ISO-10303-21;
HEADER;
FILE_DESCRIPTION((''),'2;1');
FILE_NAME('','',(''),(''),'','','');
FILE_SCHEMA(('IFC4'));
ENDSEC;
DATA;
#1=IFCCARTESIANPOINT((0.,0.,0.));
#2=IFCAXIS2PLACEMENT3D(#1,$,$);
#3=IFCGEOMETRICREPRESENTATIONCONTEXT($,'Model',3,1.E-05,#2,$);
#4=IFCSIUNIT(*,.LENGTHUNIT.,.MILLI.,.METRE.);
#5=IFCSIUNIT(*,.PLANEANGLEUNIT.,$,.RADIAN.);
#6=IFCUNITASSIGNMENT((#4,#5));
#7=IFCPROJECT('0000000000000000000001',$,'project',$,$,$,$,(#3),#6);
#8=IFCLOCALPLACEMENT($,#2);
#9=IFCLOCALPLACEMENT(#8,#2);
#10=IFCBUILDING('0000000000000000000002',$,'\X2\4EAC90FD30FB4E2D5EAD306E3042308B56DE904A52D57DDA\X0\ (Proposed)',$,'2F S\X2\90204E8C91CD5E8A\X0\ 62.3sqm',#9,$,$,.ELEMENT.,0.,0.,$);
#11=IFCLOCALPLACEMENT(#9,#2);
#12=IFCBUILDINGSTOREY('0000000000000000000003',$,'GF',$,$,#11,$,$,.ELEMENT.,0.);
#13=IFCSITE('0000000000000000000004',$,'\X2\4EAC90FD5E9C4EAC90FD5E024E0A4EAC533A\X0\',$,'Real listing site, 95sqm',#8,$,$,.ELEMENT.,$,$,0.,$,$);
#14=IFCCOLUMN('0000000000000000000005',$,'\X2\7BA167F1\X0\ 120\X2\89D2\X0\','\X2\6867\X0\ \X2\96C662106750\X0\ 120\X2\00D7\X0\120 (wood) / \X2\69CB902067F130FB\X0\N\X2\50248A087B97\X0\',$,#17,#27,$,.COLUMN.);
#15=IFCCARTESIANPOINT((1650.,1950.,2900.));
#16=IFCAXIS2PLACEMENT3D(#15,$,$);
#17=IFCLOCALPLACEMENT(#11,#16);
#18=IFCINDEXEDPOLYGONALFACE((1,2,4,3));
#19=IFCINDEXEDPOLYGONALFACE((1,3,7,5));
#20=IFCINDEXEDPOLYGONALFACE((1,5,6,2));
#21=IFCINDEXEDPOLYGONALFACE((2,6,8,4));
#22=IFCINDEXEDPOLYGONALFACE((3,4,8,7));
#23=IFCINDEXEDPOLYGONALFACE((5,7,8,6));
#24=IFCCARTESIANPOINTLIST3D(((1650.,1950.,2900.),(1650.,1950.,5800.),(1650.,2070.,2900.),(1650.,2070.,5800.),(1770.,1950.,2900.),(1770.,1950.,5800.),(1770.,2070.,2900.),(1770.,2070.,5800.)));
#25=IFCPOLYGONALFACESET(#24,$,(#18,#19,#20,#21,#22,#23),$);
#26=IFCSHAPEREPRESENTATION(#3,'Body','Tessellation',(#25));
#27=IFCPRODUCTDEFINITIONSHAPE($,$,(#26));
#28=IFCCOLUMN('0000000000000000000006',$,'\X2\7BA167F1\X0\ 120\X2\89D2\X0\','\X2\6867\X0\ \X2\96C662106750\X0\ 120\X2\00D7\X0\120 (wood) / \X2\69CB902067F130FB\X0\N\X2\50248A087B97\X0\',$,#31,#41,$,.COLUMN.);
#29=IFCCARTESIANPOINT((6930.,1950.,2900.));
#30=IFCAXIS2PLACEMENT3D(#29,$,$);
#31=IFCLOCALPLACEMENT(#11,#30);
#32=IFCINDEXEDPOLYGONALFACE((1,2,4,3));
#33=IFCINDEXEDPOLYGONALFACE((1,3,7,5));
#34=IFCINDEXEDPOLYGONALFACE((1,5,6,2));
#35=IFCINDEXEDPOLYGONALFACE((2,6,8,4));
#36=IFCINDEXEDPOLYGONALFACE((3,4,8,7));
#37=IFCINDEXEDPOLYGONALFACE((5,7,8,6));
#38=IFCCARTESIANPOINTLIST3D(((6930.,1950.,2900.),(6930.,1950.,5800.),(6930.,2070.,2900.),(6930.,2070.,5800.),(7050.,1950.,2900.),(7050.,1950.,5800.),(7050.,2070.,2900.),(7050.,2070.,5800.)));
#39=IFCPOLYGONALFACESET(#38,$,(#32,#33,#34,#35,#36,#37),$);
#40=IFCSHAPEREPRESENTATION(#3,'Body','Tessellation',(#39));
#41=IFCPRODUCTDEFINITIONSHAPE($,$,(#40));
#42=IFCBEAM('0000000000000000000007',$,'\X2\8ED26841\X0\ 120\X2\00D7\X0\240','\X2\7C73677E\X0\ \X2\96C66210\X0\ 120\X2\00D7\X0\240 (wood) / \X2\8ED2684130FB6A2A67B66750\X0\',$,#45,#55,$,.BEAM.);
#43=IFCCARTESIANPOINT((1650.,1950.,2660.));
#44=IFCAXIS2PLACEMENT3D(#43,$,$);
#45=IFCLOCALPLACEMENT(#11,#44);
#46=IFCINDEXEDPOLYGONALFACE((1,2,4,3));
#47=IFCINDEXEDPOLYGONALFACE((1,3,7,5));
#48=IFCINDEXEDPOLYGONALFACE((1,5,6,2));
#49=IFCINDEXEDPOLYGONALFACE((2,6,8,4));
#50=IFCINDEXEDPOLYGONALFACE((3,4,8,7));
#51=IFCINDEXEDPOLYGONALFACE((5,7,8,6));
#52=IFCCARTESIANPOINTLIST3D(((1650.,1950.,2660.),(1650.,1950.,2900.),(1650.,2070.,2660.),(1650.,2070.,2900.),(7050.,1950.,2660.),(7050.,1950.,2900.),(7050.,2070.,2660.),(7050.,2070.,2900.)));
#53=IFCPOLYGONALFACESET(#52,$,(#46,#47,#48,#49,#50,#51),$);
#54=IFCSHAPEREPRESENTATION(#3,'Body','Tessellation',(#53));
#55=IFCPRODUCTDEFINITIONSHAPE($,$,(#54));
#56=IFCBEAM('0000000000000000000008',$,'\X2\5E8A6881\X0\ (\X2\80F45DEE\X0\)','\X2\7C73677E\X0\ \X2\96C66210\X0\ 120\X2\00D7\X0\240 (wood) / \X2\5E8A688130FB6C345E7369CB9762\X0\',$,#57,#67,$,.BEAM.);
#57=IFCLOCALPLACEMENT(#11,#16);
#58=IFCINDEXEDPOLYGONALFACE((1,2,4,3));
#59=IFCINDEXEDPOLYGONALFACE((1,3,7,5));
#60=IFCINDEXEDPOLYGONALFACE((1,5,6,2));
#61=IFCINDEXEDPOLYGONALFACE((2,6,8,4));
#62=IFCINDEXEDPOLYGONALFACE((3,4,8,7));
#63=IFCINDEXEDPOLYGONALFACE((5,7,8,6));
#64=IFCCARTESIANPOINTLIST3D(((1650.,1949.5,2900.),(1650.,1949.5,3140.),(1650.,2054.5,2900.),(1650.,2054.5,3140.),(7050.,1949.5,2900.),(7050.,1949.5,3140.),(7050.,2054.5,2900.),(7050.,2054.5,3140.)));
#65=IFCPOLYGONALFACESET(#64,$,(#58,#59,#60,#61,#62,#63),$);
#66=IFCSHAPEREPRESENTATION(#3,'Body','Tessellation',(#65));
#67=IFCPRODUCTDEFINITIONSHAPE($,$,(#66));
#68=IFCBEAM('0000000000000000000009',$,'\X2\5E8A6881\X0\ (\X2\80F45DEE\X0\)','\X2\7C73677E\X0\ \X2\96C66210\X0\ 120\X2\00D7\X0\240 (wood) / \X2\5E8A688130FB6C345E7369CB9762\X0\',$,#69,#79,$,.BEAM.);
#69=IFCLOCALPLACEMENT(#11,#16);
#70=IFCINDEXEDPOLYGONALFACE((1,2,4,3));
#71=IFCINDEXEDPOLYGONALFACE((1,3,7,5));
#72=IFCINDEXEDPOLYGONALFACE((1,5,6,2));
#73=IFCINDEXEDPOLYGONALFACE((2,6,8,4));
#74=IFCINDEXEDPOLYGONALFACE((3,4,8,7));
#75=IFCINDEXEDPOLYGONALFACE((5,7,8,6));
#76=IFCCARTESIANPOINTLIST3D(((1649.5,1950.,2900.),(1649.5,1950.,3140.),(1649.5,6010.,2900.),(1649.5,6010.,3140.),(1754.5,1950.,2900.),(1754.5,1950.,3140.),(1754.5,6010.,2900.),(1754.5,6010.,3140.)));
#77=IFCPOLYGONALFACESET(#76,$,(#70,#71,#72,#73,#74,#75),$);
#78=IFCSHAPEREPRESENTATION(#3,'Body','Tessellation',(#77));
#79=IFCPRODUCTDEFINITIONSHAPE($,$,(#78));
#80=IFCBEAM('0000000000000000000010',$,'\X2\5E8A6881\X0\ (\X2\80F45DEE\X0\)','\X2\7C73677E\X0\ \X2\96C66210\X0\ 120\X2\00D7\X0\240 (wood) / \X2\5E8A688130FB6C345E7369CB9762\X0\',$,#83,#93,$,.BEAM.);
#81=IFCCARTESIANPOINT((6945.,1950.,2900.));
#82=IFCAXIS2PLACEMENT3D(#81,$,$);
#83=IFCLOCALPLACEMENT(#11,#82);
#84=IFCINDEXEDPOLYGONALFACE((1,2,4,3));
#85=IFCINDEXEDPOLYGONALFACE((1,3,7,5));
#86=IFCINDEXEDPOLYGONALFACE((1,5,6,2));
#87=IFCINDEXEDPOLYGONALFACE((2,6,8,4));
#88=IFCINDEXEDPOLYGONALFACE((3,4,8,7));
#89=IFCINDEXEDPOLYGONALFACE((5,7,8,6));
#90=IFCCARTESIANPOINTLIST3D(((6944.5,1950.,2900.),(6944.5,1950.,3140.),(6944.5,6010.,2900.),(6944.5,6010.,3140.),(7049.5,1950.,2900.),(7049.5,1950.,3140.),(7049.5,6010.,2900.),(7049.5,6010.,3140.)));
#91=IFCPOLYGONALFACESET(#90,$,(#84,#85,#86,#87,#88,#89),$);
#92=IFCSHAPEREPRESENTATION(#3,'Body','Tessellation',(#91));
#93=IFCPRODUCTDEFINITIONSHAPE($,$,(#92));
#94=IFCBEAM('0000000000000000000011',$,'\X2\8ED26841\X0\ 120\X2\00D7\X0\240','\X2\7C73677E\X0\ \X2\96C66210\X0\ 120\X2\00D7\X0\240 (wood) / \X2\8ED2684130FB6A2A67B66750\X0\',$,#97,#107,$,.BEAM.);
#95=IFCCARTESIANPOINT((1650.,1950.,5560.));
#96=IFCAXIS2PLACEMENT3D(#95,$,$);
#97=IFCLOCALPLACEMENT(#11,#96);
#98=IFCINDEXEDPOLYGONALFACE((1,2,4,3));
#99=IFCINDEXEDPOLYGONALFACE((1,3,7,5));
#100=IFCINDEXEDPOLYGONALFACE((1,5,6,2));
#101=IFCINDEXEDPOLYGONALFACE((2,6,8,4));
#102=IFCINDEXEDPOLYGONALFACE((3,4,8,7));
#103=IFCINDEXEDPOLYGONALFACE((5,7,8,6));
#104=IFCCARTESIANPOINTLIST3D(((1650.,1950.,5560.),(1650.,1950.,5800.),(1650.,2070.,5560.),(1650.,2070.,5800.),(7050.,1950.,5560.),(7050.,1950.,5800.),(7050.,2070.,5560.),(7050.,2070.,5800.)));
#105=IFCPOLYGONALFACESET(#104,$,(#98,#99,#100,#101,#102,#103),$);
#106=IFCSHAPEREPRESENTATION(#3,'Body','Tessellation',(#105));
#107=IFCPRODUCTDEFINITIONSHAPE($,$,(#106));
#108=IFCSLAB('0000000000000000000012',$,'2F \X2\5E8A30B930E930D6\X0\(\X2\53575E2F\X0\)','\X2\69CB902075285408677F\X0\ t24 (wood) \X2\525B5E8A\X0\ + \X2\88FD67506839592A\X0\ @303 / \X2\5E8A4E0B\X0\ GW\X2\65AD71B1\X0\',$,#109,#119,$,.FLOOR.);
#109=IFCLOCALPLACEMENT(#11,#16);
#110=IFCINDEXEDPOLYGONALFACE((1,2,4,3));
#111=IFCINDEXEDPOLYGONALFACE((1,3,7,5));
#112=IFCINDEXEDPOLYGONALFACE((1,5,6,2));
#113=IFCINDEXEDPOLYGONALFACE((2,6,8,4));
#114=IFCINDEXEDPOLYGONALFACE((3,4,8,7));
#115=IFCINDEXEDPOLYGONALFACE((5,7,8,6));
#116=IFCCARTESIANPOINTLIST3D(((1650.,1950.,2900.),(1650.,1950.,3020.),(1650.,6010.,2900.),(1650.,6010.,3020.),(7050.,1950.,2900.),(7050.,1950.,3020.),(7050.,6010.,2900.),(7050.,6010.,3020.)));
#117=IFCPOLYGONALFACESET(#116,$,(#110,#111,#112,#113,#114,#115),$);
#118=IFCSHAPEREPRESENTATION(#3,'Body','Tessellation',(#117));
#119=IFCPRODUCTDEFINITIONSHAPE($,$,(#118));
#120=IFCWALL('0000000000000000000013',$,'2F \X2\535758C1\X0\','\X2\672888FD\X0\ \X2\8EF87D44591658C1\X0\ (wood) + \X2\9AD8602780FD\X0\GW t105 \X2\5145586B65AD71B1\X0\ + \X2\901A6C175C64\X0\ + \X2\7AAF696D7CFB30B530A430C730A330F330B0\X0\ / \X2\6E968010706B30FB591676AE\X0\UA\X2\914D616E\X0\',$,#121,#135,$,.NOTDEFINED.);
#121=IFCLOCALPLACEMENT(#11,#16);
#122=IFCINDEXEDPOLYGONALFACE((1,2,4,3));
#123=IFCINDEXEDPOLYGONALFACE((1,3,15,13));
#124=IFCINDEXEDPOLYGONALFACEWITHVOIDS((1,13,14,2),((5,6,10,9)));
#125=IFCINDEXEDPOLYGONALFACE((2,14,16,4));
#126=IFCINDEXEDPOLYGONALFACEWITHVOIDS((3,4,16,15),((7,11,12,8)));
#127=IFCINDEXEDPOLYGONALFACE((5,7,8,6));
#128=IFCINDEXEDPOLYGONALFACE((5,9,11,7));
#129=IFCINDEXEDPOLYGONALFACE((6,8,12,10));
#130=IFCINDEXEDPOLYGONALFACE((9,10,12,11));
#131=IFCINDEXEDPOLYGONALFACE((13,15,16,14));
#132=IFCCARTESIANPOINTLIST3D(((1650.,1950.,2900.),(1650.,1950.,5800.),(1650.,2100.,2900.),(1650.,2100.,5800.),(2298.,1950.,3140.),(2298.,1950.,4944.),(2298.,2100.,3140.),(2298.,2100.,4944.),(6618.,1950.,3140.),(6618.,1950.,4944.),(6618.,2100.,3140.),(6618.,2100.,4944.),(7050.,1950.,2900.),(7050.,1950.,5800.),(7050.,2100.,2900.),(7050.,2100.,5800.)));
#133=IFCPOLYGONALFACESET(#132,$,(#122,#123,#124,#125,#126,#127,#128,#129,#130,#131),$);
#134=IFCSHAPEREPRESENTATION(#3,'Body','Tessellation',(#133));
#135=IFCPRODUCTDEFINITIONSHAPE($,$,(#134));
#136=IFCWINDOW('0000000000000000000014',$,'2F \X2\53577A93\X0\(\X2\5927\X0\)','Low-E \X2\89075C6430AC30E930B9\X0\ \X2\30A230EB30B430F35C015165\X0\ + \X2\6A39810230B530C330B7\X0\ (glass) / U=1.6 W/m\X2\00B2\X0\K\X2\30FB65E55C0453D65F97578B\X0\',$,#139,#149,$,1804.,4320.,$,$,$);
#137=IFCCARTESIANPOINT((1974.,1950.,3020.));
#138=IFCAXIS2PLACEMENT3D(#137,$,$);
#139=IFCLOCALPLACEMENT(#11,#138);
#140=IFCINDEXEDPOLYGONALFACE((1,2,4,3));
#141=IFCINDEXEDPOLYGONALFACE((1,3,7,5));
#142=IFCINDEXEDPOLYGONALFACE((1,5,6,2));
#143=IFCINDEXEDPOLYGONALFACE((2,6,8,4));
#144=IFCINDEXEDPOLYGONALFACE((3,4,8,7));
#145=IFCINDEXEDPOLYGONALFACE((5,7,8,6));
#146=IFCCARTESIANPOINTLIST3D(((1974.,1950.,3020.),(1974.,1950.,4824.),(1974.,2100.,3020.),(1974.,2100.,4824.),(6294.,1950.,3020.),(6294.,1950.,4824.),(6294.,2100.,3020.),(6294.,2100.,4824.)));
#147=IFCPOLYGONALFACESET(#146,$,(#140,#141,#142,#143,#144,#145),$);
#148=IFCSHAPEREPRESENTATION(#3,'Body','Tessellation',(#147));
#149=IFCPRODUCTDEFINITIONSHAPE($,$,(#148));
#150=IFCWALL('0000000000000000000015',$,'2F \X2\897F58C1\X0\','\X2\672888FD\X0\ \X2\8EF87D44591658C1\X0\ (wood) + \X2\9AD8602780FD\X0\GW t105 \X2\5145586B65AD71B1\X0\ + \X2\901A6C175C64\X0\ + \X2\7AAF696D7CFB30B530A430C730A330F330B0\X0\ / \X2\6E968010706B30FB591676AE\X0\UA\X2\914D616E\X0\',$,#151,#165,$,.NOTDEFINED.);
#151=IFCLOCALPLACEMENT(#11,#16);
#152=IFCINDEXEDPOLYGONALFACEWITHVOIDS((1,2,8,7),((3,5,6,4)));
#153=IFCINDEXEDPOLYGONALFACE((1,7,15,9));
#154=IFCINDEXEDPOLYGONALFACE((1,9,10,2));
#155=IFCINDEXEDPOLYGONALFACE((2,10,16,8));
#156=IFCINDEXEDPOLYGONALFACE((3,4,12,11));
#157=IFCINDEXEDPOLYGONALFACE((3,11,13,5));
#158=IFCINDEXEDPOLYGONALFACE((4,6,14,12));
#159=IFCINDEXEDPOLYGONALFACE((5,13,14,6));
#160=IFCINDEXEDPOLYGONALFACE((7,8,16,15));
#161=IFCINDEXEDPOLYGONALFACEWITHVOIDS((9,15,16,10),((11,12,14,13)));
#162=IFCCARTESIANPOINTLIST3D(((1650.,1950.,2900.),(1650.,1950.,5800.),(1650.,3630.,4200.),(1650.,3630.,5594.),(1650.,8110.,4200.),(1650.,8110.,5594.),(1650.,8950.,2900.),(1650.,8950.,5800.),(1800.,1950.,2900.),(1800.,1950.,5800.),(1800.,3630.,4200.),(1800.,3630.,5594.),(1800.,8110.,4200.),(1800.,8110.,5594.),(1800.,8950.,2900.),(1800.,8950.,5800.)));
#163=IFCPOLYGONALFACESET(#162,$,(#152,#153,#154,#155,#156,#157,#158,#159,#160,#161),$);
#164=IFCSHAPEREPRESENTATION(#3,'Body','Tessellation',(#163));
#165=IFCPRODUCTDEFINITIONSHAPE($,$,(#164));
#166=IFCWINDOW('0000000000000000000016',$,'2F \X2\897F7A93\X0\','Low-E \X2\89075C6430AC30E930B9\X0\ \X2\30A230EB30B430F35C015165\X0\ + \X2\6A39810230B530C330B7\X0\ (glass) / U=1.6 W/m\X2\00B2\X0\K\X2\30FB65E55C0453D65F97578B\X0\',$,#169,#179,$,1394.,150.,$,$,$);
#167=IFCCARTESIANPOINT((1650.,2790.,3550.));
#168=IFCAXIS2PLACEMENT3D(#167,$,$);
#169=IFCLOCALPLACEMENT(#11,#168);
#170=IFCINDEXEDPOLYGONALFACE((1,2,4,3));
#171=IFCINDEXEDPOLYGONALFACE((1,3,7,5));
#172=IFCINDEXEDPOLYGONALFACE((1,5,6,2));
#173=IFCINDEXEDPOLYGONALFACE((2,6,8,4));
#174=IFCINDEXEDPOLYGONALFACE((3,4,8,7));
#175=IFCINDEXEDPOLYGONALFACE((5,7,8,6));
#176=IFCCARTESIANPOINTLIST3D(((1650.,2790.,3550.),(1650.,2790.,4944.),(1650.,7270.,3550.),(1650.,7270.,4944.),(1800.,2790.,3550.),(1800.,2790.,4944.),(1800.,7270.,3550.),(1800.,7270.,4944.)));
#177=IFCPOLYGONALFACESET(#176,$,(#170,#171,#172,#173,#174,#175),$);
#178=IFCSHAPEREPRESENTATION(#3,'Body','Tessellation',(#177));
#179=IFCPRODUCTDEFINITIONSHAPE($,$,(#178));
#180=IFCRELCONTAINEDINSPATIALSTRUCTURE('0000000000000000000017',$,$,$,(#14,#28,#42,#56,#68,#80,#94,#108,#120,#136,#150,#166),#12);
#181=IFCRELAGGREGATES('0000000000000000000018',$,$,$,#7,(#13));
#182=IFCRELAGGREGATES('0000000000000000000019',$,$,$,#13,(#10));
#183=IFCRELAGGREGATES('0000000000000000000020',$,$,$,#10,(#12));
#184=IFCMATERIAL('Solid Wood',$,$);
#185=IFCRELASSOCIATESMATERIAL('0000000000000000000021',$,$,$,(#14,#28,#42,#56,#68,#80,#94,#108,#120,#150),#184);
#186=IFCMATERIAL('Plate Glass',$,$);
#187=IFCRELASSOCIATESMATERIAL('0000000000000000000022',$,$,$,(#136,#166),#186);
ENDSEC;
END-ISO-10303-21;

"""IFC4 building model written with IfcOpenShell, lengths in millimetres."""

from ifc_helpers import new_model, si_unit, frame, frame_2d, origin, place, context, project, spatial, rectangle, extrude, material, element, fill, save


model = new_model("IFC4")

# Units and contexts
model_context = context("Model", 3, precision=1e-05, world=origin())
ifc_project = project(units=[si_unit("LENGTHUNIT", "METRE", prefix="MILLI"), si_unit("PLANEANGLEUNIT", "RADIAN")], contexts=[model_context])

# Site, building, storey
site_placement = place(None, origin())
site = spatial("IfcSite", under=ifc_project, at=site_placement, Name="京都府京都市上京区", ObjectType="Real listing site, 95sqm", CompositionType="ELEMENT", RefElevation=0.0)
building_placement = place(site_placement, origin())
building = spatial("IfcBuilding", under=site, at=building_placement, Name="京都・中庭のある回遊動線 (Proposed)", ObjectType="2F S造二重床 62.3sqm", CompositionType="ELEMENT", ElevationOfRefHeight=0.0, ElevationOfTerrain=0.0)
storey_placement = place(building_placement, origin())
storey = spatial("IfcBuildingStorey", under=building, at=storey_placement, Name="GF", CompositionType="ELEMENT", Elevation=0.0)

# Columns
ifc_material_1 = material(Name="Solid Wood")
column_1_placement = place(storey_placement, frame((1650.0, 1950.0, 2900.0)))
element("IfcColumn", 1, at=column_1_placement, inside=storey, material=ifc_material_1, Name="管柱 120角", Description="桧 集成材 120×120 (wood) / 構造柱・N値計算", PredefinedType="COLUMN", context=model_context, shape_type="SweptSolid", body=[
    extrude(rectangle(XDim=120.0, YDim=120.0, at=frame_2d((60.0, 60.0))), frame((1650.0, 1950.0, 2900.0)), (0.0, 0.0, 1.0), 2900.0),
])
column_2_placement = place(storey_placement, frame((6930.0, 1950.0, 2900.0)))
element("IfcColumn", 2, at=column_2_placement, inside=storey, material=ifc_material_1, Name="管柱 120角", Description="桧 集成材 120×120 (wood) / 構造柱・N値計算", PredefinedType="COLUMN", context=model_context, shape_type="SweptSolid", body=[
    extrude(rectangle(XDim=120.0, YDim=120.0, at=frame_2d((60.0, 60.0))), frame((6930.0, 1950.0, 2900.0)), (0.0, 0.0, 1.0), 2900.0),
])

# Beams
beam_1_placement = place(storey_placement, frame((1650.0, 1950.0, 2660.0)))
element("IfcBeam", 3, at=beam_1_placement, inside=storey, material=ifc_material_1, Name="軒桁 120×240", Description="米松 集成 120×240 (wood) / 軒桁・横架材", PredefinedType="BEAM", context=model_context, shape_type="SweptSolid", body=[
    extrude(rectangle(XDim=5400.0, YDim=120.0, at=frame_2d((2700.0, 60.0))), frame((1650.0, 1950.0, 2660.0)), (0.0, 0.0, 1.0), 240.0),
])
beam_2_placement = place(storey_placement, frame((1650.0, 1950.0, 2900.0)))
element("IfcBeam", 4, at=beam_2_placement, inside=storey, material=ifc_material_1, Name="床梁 (胴差)", Description="米松 集成 120×240 (wood) / 床梁・水平構面", PredefinedType="BEAM", context=model_context, shape_type="SweptSolid", body=[
    extrude(rectangle(XDim=5400.0, YDim=105.0, at=frame_2d((2700.0, 52.0))), frame((1650.0, 1950.0, 2900.0)), (0.0, 0.0, 1.0), 240.0),
])
beam_3_placement = place(storey_placement, frame((1650.0, 1950.0, 2900.0)))
element("IfcBeam", 5, at=beam_3_placement, inside=storey, material=ifc_material_1, Name="床梁 (胴差)", Description="米松 集成 120×240 (wood) / 床梁・水平構面", PredefinedType="BEAM", context=model_context, shape_type="SweptSolid", body=[
    extrude(rectangle(XDim=105.0, YDim=4060.0, at=frame_2d((52.0, 2030.0))), frame((1650.0, 1950.0, 2900.0)), (0.0, 0.0, 1.0), 240.0),
])
beam_4_placement = place(storey_placement, frame((6945.0, 1950.0, 2900.0)))
element("IfcBeam", 6, at=beam_4_placement, inside=storey, material=ifc_material_1, Name="床梁 (胴差)", Description="米松 集成 120×240 (wood) / 床梁・水平構面", PredefinedType="BEAM", context=model_context, shape_type="SweptSolid", body=[
    extrude(rectangle(XDim=105.0, YDim=4060.0, at=frame_2d((52.0, 2030.0))), frame((6945.0, 1950.0, 2900.0)), (0.0, 0.0, 1.0), 240.0),
])
beam_5_placement = place(storey_placement, frame((1650.0, 1950.0, 5560.0)))
element("IfcBeam", 7, at=beam_5_placement, inside=storey, material=ifc_material_1, Name="軒桁 120×240", Description="米松 集成 120×240 (wood) / 軒桁・横架材", PredefinedType="BEAM", context=model_context, shape_type="SweptSolid", body=[
    extrude(rectangle(XDim=5400.0, YDim=120.0, at=frame_2d((2700.0, 60.0))), frame((1650.0, 1950.0, 5560.0)), (0.0, 0.0, 1.0), 240.0),
])

# Slab
slab_placement = place(storey_placement, frame((1650.0, 1950.0, 2900.0)))
element("IfcSlab", 8, at=slab_placement, inside=storey, material=ifc_material_1, Name="2F 床スラブ(南帯)", Description="構造用合板 t24 (wood) 剛床 + 製材根太 @303 / 床下 GW断熱", PredefinedType="FLOOR", context=model_context, shape_type="SweptSolid", body=[
    extrude(rectangle(XDim=5400.0, YDim=4060.0, at=frame_2d((2700.0, 2030.0))), frame((1650.0, 1950.0, 2900.0)), (0.0, 0.0, 1.0), 120.0),
])

# Walls, openings, windows
wall_1_placement = place(storey_placement, frame((1650.0, 1950.0, 2900.0)))
wall_1 = element("IfcWall", 9, at=wall_1_placement, inside=storey, material=ifc_material_1, Name="2F 南壁", Description="木製 軸組外壁 (wood) + 高性能GW t105 充填断熱 + 通気層 + 窯業系サイディング / 準耐火・外皮UA配慮", PredefinedType="NOTDEFINED", context=model_context, shape_type="SweptSolid", body=[
    extrude(rectangle(XDim=5400.0, YDim=150.0, at=frame_2d((2700.0, 75.0))), frame((1650.0, 1950.0, 2900.0)), (0.0, 0.0, 1.0), 2900.0),
])
opening_1_placement = place(storey_placement, frame((1974.0, 1950.0, 3020.0)))
opening_1 = element("IfcOpeningElement", 10, at=opening_1_placement, cuts=wall_1, PredefinedType="NOTDEFINED", context=model_context, shape_type="SweptSolid", body=[
    extrude(rectangle(XDim=4320.0, YDim=150.0, at=frame_2d((2160.0, 75.0))), frame((1974.0, 1950.0, 3020.0)), (0.0, 0.0, 1.0), 1804.0),
])
ifc_material_2 = material(Name="Plate Glass")
window_1_placement = place(storey_placement, frame((1974.0, 1950.0, 3020.0)))
window_1 = element("IfcWindow", 11, at=window_1_placement, inside=storey, material=ifc_material_2, Name="2F 南窓(大)", Description="Low-E 複層ガラス アルゴン封入 + 樹脂サッシ (glass) / U=1.6 W/m²K・日射取得型", OverallHeight=1804.0, OverallWidth=4320.0, context=model_context, shape_type="SweptSolid", body=[
    extrude(rectangle(XDim=4320.0, YDim=150.0, at=frame_2d((2160.0, 75.0))), frame((1974.0, 1950.0, 3020.0)), (0.0, 0.0, 1.0), 1804.0),
])
fill(opening_1, window_1)
wall_2_placement = place(storey_placement, frame((1650.0, 1950.0, 2900.0)))
wall_2 = element("IfcWall", 12, at=wall_2_placement, inside=storey, material=ifc_material_1, Name="2F 西壁", Description="木製 軸組外壁 (wood) + 高性能GW t105 充填断熱 + 通気層 + 窯業系サイディング / 準耐火・外皮UA配慮", PredefinedType="NOTDEFINED", context=model_context, shape_type="SweptSolid", body=[
    extrude(rectangle(XDim=150.0, YDim=7000.0, at=frame_2d((75.0, 3500.0))), frame((1650.0, 1950.0, 2900.0)), (0.0, 0.0, 1.0), 2900.0),
])
opening_2_placement = place(storey_placement, frame((1650.0, 2790.0, 3550.0)))
opening_2 = element("IfcOpeningElement", 13, at=opening_2_placement, cuts=wall_2, PredefinedType="NOTDEFINED", context=model_context, shape_type="SweptSolid", body=[
    extrude(rectangle(XDim=150.0, YDim=4480.0, at=frame_2d((75.0, 2240.0))), frame((1650.0, 2790.0, 3550.0)), (0.0, 0.0, 1.0), 1394.0),
])
window_2_placement = place(storey_placement, frame((1650.0, 2790.0, 3550.0)))
window_2 = element("IfcWindow", 14, at=window_2_placement, inside=storey, material=ifc_material_2, Name="2F 西窓", Description="Low-E 複層ガラス アルゴン封入 + 樹脂サッシ (glass) / U=1.6 W/m²K・日射取得型", OverallHeight=1394.0, OverallWidth=150.0, context=model_context, shape_type="SweptSolid", body=[
    extrude(rectangle(XDim=150.0, YDim=4480.0, at=frame_2d((75.0, 2240.0))), frame((1650.0, 2790.0, 3550.0)), (0.0, 0.0, 1.0), 1394.0),
])
fill(opening_2, window_2)

save(model, "model.ifc")
